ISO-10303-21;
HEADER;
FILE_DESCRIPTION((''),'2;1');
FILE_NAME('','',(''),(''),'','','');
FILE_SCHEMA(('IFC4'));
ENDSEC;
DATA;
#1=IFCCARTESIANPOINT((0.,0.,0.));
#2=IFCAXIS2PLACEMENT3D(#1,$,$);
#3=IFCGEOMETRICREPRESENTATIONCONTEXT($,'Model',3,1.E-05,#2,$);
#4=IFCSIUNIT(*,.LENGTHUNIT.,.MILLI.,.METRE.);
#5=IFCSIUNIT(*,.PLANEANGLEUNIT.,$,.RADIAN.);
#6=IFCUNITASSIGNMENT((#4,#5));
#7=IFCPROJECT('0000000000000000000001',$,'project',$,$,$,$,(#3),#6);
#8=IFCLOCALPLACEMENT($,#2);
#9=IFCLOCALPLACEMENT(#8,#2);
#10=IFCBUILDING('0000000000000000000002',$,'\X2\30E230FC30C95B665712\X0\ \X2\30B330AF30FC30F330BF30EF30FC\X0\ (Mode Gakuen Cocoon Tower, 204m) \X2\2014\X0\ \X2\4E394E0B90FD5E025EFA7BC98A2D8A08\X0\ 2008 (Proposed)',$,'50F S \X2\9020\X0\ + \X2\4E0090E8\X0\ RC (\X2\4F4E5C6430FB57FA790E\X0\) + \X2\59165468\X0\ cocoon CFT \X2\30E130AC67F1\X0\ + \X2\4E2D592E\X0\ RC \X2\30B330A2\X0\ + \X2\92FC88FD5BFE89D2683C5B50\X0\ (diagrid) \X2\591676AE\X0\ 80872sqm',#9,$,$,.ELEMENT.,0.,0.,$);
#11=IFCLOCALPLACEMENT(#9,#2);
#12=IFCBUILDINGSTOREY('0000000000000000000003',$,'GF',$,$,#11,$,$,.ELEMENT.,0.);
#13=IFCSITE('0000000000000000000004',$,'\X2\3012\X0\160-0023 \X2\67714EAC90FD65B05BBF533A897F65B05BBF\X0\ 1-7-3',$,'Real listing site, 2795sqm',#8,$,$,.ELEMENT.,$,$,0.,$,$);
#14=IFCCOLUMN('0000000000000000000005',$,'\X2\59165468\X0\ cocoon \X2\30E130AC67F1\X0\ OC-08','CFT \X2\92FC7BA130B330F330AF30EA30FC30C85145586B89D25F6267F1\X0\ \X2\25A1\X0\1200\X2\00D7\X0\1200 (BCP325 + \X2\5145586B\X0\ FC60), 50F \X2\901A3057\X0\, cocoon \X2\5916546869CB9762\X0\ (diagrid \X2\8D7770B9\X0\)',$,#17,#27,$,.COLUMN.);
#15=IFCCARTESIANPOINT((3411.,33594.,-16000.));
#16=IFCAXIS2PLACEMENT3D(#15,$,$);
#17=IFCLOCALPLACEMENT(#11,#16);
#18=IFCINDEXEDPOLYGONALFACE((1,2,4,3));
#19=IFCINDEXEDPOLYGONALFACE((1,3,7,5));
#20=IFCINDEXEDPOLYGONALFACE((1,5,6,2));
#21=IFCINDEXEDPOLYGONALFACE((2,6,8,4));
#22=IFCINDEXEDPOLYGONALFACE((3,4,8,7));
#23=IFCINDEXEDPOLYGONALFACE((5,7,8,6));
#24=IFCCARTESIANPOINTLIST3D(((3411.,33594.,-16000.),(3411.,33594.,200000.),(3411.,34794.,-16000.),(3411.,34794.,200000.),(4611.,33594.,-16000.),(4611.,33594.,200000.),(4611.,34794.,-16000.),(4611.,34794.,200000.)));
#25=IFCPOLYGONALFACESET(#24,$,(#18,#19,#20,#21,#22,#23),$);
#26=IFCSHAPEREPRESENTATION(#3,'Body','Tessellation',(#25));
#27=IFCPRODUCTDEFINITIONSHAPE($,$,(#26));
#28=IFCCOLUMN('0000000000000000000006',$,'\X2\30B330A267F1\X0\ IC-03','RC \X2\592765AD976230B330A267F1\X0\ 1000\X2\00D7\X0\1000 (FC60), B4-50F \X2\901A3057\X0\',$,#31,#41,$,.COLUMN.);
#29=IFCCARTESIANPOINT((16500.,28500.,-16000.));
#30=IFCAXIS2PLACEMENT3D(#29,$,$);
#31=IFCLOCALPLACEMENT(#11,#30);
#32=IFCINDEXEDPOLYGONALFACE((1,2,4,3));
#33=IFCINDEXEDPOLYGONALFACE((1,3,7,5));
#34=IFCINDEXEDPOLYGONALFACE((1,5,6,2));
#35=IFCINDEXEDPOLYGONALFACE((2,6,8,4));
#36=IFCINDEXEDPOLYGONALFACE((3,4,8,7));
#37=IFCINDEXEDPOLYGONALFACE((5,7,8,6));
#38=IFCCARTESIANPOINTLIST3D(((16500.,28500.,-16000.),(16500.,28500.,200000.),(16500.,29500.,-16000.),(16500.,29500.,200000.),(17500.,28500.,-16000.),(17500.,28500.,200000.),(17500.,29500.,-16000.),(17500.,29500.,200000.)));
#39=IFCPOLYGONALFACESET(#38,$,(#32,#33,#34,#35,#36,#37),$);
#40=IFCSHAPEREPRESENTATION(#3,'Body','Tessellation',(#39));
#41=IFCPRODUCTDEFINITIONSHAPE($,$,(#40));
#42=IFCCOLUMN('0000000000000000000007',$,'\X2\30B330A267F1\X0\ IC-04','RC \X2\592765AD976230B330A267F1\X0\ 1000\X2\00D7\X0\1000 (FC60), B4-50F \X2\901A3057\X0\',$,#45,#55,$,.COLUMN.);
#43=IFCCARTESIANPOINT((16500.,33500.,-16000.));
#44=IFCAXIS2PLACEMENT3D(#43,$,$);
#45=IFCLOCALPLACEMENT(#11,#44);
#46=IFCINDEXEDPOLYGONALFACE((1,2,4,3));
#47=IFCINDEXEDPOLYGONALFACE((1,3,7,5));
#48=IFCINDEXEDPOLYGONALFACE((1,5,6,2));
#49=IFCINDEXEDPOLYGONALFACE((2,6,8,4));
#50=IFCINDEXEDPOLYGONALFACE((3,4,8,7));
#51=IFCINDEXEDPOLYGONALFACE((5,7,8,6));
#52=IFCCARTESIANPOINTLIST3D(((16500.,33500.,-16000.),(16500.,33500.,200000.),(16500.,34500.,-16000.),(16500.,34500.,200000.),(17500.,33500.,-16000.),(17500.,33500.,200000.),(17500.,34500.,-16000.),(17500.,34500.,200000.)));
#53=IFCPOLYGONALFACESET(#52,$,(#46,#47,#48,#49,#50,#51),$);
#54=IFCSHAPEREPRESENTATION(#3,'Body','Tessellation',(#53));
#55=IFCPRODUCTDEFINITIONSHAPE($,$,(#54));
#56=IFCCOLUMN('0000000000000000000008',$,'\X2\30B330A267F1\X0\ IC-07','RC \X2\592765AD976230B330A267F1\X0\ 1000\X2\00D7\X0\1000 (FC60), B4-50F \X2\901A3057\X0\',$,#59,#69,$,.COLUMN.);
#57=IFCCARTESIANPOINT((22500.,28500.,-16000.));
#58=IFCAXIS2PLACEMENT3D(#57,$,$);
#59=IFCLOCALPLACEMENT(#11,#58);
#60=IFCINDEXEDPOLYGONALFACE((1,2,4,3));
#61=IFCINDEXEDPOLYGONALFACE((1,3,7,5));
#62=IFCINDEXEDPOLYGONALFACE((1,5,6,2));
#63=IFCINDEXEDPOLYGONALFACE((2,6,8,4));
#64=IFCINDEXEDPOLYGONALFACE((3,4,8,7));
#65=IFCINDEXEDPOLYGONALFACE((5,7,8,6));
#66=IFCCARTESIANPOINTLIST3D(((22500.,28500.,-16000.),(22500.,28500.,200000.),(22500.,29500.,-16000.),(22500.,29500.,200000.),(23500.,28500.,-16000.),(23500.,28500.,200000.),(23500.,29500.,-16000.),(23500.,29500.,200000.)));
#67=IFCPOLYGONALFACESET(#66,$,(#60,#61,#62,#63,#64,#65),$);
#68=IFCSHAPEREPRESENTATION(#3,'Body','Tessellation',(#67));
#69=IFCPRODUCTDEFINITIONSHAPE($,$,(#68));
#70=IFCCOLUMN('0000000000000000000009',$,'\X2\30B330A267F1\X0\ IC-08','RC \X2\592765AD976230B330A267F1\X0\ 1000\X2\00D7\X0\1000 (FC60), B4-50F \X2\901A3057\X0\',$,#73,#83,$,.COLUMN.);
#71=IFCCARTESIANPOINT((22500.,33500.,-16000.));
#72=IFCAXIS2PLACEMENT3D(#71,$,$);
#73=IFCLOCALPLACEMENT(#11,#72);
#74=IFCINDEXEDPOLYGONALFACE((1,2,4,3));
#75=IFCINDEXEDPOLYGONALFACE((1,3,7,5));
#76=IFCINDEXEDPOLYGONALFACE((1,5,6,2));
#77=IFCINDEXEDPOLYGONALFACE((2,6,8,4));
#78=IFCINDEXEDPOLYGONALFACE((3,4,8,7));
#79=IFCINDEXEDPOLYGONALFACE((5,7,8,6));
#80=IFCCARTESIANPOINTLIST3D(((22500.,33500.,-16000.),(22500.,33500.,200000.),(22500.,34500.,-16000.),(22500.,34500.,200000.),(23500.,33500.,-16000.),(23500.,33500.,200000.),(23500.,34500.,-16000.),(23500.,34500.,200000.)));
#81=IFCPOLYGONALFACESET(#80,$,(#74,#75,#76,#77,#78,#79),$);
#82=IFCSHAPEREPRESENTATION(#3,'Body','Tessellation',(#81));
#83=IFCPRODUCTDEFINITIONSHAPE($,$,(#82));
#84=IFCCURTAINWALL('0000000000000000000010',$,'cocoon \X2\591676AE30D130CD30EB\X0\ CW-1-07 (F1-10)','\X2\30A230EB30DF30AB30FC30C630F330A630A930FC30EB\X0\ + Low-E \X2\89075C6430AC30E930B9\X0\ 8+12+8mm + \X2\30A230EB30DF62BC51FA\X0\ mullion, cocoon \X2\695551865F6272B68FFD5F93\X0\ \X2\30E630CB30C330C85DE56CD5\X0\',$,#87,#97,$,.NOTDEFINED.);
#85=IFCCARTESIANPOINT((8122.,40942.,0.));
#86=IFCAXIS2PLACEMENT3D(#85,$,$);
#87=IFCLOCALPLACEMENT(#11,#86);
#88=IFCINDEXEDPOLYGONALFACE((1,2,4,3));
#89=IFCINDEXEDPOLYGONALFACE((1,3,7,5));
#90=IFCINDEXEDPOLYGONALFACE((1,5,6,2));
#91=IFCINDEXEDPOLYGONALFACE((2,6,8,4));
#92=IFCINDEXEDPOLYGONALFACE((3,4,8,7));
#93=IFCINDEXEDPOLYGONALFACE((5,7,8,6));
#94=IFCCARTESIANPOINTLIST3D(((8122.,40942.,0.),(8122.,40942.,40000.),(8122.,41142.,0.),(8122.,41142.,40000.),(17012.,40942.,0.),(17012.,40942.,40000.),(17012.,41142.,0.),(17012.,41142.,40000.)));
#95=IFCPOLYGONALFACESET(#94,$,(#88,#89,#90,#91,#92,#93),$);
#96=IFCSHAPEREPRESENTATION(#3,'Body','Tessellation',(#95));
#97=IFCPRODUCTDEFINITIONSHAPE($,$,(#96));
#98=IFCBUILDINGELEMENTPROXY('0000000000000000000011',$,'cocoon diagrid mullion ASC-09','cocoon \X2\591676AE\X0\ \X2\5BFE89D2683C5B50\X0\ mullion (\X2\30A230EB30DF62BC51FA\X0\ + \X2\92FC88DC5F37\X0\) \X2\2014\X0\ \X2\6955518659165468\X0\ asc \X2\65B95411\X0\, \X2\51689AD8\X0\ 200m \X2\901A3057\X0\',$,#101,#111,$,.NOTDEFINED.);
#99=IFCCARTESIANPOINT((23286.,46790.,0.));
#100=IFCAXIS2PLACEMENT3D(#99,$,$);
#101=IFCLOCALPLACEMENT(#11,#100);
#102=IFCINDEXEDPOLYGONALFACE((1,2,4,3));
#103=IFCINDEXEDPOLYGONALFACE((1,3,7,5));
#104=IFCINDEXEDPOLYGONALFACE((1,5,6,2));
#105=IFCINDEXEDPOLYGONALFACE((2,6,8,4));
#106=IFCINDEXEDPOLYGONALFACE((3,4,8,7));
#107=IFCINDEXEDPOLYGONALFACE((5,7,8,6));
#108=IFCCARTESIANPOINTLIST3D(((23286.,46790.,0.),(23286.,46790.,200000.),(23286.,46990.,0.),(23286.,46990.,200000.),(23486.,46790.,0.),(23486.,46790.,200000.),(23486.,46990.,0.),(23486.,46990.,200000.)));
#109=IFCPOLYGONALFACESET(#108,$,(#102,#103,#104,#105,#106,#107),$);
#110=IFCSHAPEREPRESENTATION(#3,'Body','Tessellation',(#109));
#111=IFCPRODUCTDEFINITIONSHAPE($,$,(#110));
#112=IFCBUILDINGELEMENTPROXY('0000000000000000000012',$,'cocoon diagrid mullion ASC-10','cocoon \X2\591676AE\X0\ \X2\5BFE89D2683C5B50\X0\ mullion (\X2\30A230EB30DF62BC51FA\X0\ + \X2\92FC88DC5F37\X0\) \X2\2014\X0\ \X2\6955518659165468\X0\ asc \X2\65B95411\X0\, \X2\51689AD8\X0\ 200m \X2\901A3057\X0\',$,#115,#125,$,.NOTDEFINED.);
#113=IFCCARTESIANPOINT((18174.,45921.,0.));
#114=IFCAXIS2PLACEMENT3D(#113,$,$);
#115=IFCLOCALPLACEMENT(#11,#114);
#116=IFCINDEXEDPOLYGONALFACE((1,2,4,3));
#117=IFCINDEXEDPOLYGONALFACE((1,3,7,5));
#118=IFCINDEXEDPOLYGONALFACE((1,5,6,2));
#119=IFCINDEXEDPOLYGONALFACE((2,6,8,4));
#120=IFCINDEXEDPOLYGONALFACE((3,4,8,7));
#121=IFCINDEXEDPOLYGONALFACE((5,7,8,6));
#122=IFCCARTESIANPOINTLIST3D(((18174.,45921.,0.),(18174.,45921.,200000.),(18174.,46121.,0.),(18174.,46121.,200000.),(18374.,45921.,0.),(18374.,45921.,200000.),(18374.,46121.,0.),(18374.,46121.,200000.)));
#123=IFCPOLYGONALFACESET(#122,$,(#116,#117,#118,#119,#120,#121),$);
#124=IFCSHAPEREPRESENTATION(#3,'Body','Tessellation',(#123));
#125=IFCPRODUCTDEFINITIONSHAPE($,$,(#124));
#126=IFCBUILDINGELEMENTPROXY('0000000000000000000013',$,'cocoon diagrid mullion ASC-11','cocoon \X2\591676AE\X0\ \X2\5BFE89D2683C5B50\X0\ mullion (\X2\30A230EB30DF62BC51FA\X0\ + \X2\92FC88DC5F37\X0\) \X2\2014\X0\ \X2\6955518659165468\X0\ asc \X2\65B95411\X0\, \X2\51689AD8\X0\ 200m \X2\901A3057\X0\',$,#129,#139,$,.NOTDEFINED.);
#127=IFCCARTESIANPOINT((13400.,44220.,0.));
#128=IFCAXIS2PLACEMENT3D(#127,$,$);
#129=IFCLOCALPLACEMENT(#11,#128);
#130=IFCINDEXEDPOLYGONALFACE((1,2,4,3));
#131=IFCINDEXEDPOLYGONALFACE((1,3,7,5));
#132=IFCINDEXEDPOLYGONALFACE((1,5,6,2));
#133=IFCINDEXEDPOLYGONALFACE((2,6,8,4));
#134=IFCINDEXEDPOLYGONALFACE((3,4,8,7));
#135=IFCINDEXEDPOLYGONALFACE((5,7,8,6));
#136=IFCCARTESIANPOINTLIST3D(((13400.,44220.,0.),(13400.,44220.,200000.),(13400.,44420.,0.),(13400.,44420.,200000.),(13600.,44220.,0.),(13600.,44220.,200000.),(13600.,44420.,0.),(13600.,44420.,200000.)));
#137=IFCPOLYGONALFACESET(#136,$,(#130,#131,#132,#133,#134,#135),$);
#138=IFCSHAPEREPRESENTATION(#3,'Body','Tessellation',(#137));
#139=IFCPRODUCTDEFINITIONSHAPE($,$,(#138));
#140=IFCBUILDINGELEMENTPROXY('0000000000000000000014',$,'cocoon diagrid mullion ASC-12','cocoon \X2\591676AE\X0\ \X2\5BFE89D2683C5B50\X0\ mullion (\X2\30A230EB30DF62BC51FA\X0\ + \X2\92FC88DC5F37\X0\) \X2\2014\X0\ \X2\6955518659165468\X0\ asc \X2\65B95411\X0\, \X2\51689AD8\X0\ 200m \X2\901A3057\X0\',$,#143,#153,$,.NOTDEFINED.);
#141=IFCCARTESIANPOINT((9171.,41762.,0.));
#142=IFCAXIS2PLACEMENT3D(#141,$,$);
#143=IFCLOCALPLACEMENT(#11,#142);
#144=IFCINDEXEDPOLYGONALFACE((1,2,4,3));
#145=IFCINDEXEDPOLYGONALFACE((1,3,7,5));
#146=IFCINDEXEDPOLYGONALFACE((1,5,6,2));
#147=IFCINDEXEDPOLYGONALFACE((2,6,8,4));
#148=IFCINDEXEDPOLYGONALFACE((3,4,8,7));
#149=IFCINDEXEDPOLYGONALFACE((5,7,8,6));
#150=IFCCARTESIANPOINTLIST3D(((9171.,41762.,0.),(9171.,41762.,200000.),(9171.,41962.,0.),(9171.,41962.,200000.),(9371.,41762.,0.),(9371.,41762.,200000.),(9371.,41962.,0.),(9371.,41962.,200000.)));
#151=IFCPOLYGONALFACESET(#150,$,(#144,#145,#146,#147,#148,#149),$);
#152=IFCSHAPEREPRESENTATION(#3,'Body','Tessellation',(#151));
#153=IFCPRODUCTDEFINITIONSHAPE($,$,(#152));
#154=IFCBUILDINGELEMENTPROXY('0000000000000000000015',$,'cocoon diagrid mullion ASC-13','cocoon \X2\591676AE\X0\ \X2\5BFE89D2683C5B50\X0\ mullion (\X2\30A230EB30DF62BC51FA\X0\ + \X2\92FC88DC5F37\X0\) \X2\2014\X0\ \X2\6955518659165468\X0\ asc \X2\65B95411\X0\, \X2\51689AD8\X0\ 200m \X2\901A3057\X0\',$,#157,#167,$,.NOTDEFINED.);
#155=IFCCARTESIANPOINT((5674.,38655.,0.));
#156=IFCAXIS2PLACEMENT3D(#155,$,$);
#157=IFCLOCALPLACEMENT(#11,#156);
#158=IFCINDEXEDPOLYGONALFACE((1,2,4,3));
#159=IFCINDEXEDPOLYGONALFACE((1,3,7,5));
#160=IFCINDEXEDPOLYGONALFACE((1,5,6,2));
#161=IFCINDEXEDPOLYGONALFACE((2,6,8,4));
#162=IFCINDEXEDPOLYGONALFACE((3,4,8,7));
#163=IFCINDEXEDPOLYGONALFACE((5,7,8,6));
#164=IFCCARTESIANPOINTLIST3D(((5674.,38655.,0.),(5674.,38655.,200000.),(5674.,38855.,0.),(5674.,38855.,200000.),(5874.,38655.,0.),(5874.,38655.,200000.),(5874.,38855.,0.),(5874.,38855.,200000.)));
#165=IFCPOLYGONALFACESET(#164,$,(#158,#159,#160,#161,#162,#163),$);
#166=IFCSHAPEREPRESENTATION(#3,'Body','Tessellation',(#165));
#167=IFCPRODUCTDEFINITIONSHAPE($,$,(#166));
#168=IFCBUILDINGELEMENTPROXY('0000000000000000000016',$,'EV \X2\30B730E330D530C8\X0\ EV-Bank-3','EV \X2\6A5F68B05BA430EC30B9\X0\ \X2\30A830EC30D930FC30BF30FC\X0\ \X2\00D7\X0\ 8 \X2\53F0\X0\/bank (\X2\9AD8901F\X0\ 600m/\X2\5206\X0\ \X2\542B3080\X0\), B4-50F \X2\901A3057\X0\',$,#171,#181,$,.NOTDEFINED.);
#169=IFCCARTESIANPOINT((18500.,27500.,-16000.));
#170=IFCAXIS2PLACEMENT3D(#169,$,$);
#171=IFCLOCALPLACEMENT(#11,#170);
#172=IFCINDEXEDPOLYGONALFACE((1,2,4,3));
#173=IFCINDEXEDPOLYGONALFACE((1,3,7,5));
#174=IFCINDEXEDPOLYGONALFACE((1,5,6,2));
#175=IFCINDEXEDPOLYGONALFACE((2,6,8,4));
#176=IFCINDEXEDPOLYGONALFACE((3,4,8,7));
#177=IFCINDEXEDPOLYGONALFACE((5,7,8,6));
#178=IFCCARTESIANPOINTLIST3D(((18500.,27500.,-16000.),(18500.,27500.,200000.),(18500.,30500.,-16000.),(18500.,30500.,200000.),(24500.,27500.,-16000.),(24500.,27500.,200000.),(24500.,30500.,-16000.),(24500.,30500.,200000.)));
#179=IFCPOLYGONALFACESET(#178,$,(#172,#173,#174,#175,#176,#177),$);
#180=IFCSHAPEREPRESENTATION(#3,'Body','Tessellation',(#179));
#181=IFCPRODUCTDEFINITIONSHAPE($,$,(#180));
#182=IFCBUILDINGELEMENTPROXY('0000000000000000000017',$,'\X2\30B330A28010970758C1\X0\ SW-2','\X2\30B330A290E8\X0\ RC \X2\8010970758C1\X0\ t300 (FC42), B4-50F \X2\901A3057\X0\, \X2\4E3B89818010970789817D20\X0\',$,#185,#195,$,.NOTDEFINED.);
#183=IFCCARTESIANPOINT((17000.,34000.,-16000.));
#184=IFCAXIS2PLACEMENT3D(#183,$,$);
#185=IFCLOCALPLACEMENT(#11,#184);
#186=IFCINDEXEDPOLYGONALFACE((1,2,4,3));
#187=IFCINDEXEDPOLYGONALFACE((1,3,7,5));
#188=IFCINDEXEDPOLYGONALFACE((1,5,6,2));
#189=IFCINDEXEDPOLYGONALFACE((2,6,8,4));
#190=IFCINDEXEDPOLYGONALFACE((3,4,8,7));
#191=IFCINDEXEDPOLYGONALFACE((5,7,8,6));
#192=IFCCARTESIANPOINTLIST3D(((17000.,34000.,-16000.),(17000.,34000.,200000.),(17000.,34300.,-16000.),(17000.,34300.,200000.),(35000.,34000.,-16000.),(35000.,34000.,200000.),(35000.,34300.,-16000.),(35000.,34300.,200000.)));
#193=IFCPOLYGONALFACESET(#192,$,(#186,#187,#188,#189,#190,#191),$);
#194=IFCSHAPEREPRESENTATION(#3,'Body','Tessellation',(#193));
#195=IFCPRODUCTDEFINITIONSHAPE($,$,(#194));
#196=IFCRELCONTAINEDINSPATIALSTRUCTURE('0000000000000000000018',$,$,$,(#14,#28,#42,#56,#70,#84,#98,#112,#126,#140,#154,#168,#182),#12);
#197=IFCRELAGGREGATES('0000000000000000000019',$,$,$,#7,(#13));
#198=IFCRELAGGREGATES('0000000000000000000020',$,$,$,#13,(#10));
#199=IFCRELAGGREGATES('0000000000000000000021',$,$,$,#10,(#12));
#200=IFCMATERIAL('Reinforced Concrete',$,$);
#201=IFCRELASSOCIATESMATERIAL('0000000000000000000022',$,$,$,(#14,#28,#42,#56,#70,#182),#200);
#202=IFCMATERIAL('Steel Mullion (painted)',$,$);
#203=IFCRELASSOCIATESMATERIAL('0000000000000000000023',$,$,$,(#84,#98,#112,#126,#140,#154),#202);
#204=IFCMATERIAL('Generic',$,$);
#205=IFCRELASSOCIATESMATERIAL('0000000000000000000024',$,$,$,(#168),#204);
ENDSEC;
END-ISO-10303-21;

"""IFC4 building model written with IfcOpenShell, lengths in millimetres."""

from ifc_helpers import new_model, si_unit, frame, frame_2d, origin, place, context, project, spatial, rectangle, extrude, material, element, save


model = new_model("IFC4")

# Units and contexts
model_context = context("Model", 3, precision=1e-05, world=origin())
ifc_project = project(units=[si_unit("LENGTHUNIT", "METRE", prefix="MILLI"), si_unit("PLANEANGLEUNIT", "RADIAN")], contexts=[model_context])

# Site, building, storey
site_placement = place(None, origin())
site = spatial("IfcSite", under=ifc_project, at=site_placement, Name="〒160-0023 東京都新宿区西新宿 1-7-3", ObjectType="Real listing site, 2795sqm", CompositionType="ELEMENT", RefElevation=0.0)
building_placement = place(site_placement, origin())
building = spatial("IfcBuilding", under=site, at=building_placement, Name="モード学園 コクーンタワー (Mode Gakuen Cocoon Tower, 204m) — 丹下都市建築設計 2008 (Proposed)", ObjectType="50F S 造 + 一部 RC (低層・基礎) + 外周 cocoon CFT メガ柱 + 中央 RC コア + 鋼製対角格子 (diagrid) 外皮 80872sqm", CompositionType="ELEMENT", ElevationOfRefHeight=0.0, ElevationOfTerrain=0.0)
storey_placement = place(building_placement, origin())
storey = spatial("IfcBuildingStorey", under=building, at=storey_placement, Name="GF", CompositionType="ELEMENT", Elevation=0.0)

# Shared definitions
ifc_material_1 = material(Name="Reinforced Concrete")

# Columns
column_1_placement = place(storey_placement, frame((3411.0, 33594.0, -16000.0)))
element("IfcColumn", 1, at=column_1_placement, inside=storey, material=ifc_material_1, Name="外周 cocoon メガ柱 OC-08", Description="CFT 鋼管コンクリート充填角形柱 □1200×1200 (BCP325 + 充填 FC60), 50F 通し, cocoon 外周構面 (diagrid 起点)", PredefinedType="COLUMN", context=model_context, shape_type="SweptSolid", body=[
    extrude(rectangle(XDim=1200.0, YDim=1200.0, at=frame_2d((600.0, 600.0))), frame((3411.0, 33594.0, -16000.0)), (0.0, 0.0, 1.0), 216000.0),
])
column_2_placement = place(storey_placement, frame((16500.0, 28500.0, -16000.0)))
element("IfcColumn", 2, at=column_2_placement, inside=storey, material=ifc_material_1, Name="コア柱 IC-03", Description="RC 大断面コア柱 1000×1000 (FC60), B4-50F 通し", PredefinedType="COLUMN", context=model_context, shape_type="SweptSolid", body=[
    extrude(rectangle(XDim=1000.0, YDim=1000.0, at=frame_2d((500.0, 500.0))), frame((16500.0, 28500.0, -16000.0)), (0.0, 0.0, 1.0), 216000.0),
])
column_3_placement = place(storey_placement, frame((16500.0, 33500.0, -16000.0)))
element("IfcColumn", 3, at=column_3_placement, inside=storey, material=ifc_material_1, Name="コア柱 IC-04", Description="RC 大断面コア柱 1000×1000 (FC60), B4-50F 通し", PredefinedType="COLUMN", context=model_context, shape_type="SweptSolid", body=[
    extrude(rectangle(XDim=1000.0, YDim=1000.0, at=frame_2d((500.0, 500.0))), frame((16500.0, 33500.0, -16000.0)), (0.0, 0.0, 1.0), 216000.0),
])
column_4_placement = place(storey_placement, frame((22500.0, 28500.0, -16000.0)))
element("IfcColumn", 4, at=column_4_placement, inside=storey, material=ifc_material_1, Name="コア柱 IC-07", Description="RC 大断面コア柱 1000×1000 (FC60), B4-50F 通し", PredefinedType="COLUMN", context=model_context, shape_type="SweptSolid", body=[
    extrude(rectangle(XDim=1000.0, YDim=1000.0, at=frame_2d((500.0, 500.0))), frame((22500.0, 28500.0, -16000.0)), (0.0, 0.0, 1.0), 216000.0),
])
column_5_placement = place(storey_placement, frame((22500.0, 33500.0, -16000.0)))
element("IfcColumn", 5, at=column_5_placement, inside=storey, material=ifc_material_1, Name="コア柱 IC-08", Description="RC 大断面コア柱 1000×1000 (FC60), B4-50F 通し", PredefinedType="COLUMN", context=model_context, shape_type="SweptSolid", body=[
    extrude(rectangle(XDim=1000.0, YDim=1000.0, at=frame_2d((500.0, 500.0))), frame((22500.0, 33500.0, -16000.0)), (0.0, 0.0, 1.0), 216000.0),
])

# Curtain wall
ifc_material_2 = material(Name="Steel Mullion (painted)")
curtain_wall_1_placement = place(storey_placement, frame((8122.0, 40942.0, 0.0)))
element("IfcCurtainWall", 6, at=curtain_wall_1_placement, inside=storey, material=ifc_material_2, Name="cocoon 外皮パネル CW-1-07 (F1-10)", Description="アルミカーテンウォール + Low-E 複層ガラス 8+12+8mm + アルミ押出 mullion, cocoon 楕円形状追従 ユニット工法", PredefinedType="NOTDEFINED", context=model_context, shape_type="SweptSolid", body=[
    extrude(rectangle(XDim=8890.0, YDim=200.0, at=frame_2d((4445.0, 100.0))), frame((8122.0, 40942.0, 0.0)), (0.0, 0.0, 1.0), 40000.0),
])

# Building element proxies
proxy_1_placement = place(storey_placement, frame((23286.0, 46790.0, 0.0)))
element("IfcBuildingElementProxy", 7, at=proxy_1_placement, inside=storey, material=ifc_material_2, Name="cocoon diagrid mullion ASC-09", Description="cocoon 外皮 対角格子 mullion (アルミ押出 + 鋼補強) — 楕円外周 asc 方向, 全高 200m 通し", PredefinedType="NOTDEFINED", context=model_context, shape_type="SweptSolid", body=[
    extrude(rectangle(XDim=200.0, YDim=200.0, at=frame_2d((100.0, 100.0))), frame((23286.0, 46790.0, 0.0)), (0.0, 0.0, 1.0), 200000.0),
])
proxy_2_placement = place(storey_placement, frame((18174.0, 45921.0, 0.0)))
element("IfcBuildingElementProxy", 8, at=proxy_2_placement, inside=storey, material=ifc_material_2, Name="cocoon diagrid mullion ASC-10", Description="cocoon 外皮 対角格子 mullion (アルミ押出 + 鋼補強) — 楕円外周 asc 方向, 全高 200m 通し", PredefinedType="NOTDEFINED", context=model_context, shape_type="SweptSolid", body=[
    extrude(rectangle(XDim=200.0, YDim=200.0, at=frame_2d((100.0, 100.0))), frame((18174.0, 45921.0, 0.0)), (0.0, 0.0, 1.0), 200000.0),
])
proxy_3_placement = place(storey_placement, frame((13400.0, 44220.0, 0.0)))
element("IfcBuildingElementProxy", 9, at=proxy_3_placement, inside=storey, material=ifc_material_2, Name="cocoon diagrid mullion ASC-11", Description="cocoon 外皮 対角格子 mullion (アルミ押出 + 鋼補強) — 楕円外周 asc 方向, 全高 200m 通し", PredefinedType="NOTDEFINED", context=model_context, shape_type="SweptSolid", body=[
    extrude(rectangle(XDim=200.0, YDim=200.0, at=frame_2d((100.0, 100.0))), frame((13400.0, 44220.0, 0.0)), (0.0, 0.0, 1.0), 200000.0),
])
proxy_4_placement = place(storey_placement, frame((9171.0, 41762.0, 0.0)))
element("IfcBuildingElementProxy", 10, at=proxy_4_placement, inside=storey, material=ifc_material_2, Name="cocoon diagrid mullion ASC-12", Description="cocoon 外皮 対角格子 mullion (アルミ押出 + 鋼補強) — 楕円外周 asc 方向, 全高 200m 通し", PredefinedType="NOTDEFINED", context=model_context, shape_type="SweptSolid", body=[
    extrude(rectangle(XDim=200.0, YDim=200.0, at=frame_2d((100.0, 100.0))), frame((9171.0, 41762.0, 0.0)), (0.0, 0.0, 1.0), 200000.0),
])
proxy_5_placement = place(storey_placement, frame((5674.0, 38655.0, 0.0)))
element("IfcBuildingElementProxy", 11, at=proxy_5_placement, inside=storey, material=ifc_material_2, Name="cocoon diagrid mullion ASC-13", Description="cocoon 外皮 対角格子 mullion (アルミ押出 + 鋼補強) — 楕円外周 asc 方向, 全高 200m 通し", PredefinedType="NOTDEFINED", context=model_context, shape_type="SweptSolid", body=[
    extrude(rectangle(XDim=200.0, YDim=200.0, at=frame_2d((100.0, 100.0))), frame((5674.0, 38655.0, 0.0)), (0.0, 0.0, 1.0), 200000.0),
])
ifc_material_3 = material(Name="Generic")
proxy_6_placement = place(storey_placement, frame((18500.0, 27500.0, -16000.0)))
element("IfcBuildingElementProxy", 12, at=proxy_6_placement, inside=storey, material=ifc_material_3, Name="EV シャフト EV-Bank-3", Description="EV 機械室レス エレベーター × 8 台/bank (高速 600m/分 含む), B4-50F 通し", PredefinedType="NOTDEFINED", context=model_context, shape_type="SweptSolid", body=[
    extrude(rectangle(XDim=6000.0, YDim=3000.0, at=frame_2d((3000.0, 1500.0))), frame((18500.0, 27500.0, -16000.0)), (0.0, 0.0, 1.0), 216000.0),
])
proxy_7_placement = place(storey_placement, frame((17000.0, 34000.0, -16000.0)))
element("IfcBuildingElementProxy", 13, at=proxy_7_placement, inside=storey, material=ifc_material_1, Name="コア耐震壁 SW-2", Description="コア部 RC 耐震壁 t300 (FC42), B4-50F 通し, 主要耐震要素", PredefinedType="NOTDEFINED", context=model_context, shape_type="SweptSolid", body=[
    extrude(rectangle(XDim=18000.0, YDim=300.0, at=frame_2d((9000.0, 150.0))), frame((17000.0, 34000.0, -16000.0)), (0.0, 0.0, 1.0), 216000.0),
])

save(model, "model.ifc")
